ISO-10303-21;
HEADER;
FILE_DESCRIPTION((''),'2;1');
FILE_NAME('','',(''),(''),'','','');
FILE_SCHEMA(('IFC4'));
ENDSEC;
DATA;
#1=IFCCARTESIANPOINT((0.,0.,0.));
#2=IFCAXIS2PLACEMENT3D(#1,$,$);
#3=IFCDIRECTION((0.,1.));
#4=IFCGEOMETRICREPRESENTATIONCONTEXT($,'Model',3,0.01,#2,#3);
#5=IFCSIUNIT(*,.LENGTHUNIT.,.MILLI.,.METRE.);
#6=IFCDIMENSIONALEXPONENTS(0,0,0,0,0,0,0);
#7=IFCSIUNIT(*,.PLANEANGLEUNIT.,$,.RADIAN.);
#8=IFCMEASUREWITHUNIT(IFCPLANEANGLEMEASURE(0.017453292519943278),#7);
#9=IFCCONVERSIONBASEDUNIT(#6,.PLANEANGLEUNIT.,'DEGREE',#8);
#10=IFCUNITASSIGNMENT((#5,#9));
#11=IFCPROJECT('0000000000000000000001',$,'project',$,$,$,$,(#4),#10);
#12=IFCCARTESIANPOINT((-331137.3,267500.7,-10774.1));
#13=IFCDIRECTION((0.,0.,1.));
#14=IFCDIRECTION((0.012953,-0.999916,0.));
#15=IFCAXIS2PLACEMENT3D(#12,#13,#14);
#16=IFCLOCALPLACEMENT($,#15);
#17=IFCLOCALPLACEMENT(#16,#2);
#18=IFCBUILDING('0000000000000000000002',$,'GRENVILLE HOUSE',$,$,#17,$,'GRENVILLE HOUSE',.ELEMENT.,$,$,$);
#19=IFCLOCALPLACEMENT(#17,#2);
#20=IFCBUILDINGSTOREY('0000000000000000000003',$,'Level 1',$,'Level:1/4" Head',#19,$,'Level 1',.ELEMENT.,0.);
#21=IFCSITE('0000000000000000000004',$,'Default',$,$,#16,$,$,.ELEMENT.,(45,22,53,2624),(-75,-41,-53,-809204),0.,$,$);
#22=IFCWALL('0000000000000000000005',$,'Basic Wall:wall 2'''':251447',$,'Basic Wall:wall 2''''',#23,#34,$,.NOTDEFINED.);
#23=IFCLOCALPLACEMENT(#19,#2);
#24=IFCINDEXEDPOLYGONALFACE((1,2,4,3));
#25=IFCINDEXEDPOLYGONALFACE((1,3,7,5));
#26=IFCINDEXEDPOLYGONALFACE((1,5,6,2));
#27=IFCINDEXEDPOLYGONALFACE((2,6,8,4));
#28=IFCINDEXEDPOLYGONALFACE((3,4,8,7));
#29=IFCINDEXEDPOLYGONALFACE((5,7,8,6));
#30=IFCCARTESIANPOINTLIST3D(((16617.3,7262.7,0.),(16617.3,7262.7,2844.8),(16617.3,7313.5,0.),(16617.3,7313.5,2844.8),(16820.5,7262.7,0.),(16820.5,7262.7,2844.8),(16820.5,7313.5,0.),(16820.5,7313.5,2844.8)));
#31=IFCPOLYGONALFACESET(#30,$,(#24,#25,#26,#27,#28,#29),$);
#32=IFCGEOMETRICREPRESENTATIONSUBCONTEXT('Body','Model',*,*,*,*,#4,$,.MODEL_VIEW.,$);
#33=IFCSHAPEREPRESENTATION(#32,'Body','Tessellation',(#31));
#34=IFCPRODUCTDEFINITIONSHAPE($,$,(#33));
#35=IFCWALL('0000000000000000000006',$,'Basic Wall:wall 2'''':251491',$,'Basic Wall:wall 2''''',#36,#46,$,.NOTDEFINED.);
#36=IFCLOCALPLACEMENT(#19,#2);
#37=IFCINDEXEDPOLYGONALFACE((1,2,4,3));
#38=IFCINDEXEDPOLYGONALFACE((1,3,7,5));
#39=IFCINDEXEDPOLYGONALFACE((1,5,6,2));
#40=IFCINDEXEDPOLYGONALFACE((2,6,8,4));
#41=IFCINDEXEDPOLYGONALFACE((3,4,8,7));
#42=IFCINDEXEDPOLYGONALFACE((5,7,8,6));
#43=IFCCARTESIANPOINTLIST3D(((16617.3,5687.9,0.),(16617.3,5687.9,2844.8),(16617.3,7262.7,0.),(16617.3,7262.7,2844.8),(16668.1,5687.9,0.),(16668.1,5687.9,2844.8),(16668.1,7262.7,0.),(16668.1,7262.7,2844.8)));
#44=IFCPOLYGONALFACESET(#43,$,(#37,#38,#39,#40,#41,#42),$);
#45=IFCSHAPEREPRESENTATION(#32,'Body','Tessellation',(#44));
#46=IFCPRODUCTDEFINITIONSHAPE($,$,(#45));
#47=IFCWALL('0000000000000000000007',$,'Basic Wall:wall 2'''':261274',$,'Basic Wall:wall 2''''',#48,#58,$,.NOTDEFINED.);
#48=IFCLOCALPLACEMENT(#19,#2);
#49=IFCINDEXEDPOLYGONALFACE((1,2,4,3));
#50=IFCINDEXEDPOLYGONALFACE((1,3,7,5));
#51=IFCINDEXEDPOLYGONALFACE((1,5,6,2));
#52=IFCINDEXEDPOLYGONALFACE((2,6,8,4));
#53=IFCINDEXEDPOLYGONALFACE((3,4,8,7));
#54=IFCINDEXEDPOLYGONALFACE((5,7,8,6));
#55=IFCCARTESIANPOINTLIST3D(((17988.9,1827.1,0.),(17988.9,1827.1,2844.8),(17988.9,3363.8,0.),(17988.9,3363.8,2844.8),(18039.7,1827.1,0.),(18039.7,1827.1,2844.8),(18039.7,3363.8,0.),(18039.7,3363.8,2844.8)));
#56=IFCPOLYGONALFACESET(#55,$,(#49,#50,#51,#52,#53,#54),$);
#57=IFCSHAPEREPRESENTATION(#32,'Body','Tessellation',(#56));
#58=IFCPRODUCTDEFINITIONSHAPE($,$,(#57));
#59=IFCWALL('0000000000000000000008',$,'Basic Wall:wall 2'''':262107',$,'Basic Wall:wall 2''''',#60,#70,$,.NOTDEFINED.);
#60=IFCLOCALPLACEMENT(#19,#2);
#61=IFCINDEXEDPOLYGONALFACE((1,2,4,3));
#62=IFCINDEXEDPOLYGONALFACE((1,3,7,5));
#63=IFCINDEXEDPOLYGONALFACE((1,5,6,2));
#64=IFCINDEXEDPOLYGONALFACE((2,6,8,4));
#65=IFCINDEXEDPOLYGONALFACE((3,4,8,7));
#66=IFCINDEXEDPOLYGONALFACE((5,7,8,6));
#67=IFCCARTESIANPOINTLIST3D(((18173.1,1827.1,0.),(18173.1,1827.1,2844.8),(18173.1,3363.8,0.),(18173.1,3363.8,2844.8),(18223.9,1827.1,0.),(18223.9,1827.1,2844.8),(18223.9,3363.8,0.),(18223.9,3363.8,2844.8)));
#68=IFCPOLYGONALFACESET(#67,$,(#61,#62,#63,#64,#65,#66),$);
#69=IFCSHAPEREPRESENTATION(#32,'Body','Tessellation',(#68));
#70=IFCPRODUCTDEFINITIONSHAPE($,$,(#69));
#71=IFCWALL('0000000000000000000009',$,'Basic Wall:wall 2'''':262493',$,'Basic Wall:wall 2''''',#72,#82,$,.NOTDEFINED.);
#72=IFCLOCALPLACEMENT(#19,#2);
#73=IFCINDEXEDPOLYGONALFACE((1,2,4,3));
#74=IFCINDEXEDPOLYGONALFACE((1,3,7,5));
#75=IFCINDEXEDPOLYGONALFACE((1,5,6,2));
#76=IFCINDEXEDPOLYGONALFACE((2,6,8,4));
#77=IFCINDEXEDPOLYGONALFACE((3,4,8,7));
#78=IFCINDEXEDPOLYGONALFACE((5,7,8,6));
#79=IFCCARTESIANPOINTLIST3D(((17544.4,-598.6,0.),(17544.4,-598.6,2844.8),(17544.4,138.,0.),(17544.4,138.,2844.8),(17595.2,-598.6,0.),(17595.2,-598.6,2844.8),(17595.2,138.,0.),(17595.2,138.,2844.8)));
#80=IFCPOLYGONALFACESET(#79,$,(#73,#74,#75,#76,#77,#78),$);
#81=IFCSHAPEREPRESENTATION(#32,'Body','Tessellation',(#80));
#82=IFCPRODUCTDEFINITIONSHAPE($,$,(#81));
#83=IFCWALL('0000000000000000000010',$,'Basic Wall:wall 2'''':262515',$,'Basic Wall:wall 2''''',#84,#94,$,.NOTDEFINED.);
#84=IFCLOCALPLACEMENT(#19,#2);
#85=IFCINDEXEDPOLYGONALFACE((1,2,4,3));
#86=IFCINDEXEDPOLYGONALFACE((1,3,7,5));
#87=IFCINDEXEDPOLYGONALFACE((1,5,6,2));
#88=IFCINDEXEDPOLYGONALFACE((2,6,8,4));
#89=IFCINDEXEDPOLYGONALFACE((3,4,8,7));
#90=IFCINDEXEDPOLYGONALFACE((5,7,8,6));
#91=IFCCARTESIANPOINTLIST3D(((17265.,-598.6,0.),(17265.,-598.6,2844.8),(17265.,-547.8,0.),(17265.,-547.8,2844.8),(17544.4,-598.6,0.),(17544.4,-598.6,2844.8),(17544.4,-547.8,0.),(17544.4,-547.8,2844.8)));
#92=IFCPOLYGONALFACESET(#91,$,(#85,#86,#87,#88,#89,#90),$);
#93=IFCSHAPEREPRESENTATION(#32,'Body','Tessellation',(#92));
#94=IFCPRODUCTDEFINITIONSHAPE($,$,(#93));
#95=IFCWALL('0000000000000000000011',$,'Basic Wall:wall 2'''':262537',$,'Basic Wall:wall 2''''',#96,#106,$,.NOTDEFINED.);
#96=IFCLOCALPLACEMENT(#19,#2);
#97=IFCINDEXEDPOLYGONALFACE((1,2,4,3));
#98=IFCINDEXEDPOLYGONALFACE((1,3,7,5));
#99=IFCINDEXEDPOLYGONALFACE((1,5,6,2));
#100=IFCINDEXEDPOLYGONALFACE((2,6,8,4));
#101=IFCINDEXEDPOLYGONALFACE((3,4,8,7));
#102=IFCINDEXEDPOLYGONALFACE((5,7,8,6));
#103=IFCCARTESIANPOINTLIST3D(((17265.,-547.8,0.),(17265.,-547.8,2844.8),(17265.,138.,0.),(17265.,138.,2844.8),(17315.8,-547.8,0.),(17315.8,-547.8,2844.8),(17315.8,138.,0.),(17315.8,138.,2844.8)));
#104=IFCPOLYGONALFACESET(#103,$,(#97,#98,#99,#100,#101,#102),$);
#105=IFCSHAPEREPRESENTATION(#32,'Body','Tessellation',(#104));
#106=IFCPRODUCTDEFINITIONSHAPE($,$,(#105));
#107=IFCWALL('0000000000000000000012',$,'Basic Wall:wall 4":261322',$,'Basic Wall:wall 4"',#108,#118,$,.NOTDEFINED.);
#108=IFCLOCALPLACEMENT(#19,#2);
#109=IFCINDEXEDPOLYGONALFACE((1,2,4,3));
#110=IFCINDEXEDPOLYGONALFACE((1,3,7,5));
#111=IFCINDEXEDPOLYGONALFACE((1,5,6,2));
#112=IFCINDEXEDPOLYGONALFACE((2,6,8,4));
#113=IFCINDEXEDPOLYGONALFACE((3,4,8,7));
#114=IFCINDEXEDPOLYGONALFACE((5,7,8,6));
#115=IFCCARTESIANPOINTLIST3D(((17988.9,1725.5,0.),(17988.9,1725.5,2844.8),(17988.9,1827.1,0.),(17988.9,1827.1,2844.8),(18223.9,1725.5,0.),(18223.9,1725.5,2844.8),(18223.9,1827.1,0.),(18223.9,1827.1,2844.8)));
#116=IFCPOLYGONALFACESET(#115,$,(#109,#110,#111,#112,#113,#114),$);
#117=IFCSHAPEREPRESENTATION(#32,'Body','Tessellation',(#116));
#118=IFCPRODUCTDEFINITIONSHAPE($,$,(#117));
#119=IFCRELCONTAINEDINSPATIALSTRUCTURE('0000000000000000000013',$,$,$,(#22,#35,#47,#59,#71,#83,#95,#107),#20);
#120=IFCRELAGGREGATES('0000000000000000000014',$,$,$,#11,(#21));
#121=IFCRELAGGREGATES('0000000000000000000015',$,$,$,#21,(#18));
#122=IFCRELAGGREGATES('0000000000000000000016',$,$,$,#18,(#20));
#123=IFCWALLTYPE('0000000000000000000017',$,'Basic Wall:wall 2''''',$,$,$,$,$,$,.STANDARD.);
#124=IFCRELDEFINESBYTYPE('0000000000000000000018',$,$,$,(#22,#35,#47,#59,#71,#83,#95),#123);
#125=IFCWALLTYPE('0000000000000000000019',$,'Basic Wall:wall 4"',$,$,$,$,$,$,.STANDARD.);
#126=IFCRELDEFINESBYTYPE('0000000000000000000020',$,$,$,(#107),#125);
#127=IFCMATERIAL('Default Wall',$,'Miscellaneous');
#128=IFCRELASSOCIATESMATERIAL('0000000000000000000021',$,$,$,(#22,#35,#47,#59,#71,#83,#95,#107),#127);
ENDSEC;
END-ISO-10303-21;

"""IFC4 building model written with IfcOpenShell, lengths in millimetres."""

from ifc_helpers import new_model, entity, si_unit, converted_unit, direction, frame, origin, place, context, subcontext, project, spatial, indexed_curve, outline, extrude, material, type_object, element, save


model = new_model("IFC4")

# Units and contexts
model_context = context("Model", 3, precision=0.01, world=origin(), true_north=direction((0.0, 1.0)))
body_context = subcontext(model_context, "Body", "Model", "MODEL_VIEW")
ifc_project = project(units=[si_unit("LENGTHUNIT", "METRE", prefix="MILLI"), converted_unit("PLANEANGLEUNIT", "DEGREE", entity("IfcPlaneAngleMeasure", 0.017453292519943278), si_unit("PLANEANGLEUNIT", "RADIAN"), dimensions=[0, 0, 0, 0, 0, 0, 0])], contexts=[model_context])

# Site, building, storey
site_placement = place(None, frame((-331137.3, 267500.7, -10774.1), z_axis=(0.0, 0.0, 1.0), x_axis=(0.012953, -0.999916, 0.0)))
site = spatial("IfcSite", under=ifc_project, at=site_placement, Name="Default", CompositionType="ELEMENT", RefLatitude=(45, 22, 53, 2624), RefLongitude=(-75, -41, -53, -809204), RefElevation=0.0)
building_placement = place(site_placement, origin())
building = spatial("IfcBuilding", under=site, at=building_placement, Name="GRENVILLE HOUSE", LongName="GRENVILLE HOUSE", CompositionType="ELEMENT")
storey_placement = place(building_placement, origin())
storey = spatial("IfcBuildingStorey", under=building, at=storey_placement, Name="Level 1", ObjectType="Level:1/4\" Head", LongName="Level 1", CompositionType="ELEMENT", Elevation=0.0)

# Walls
ifc_material_1 = material(Name="Default Wall", Category="Miscellaneous")
wall_type_1 = type_object("IfcWallType", Name="Basic Wall:wall 2''", PredefinedType="STANDARD")
wall_1_placement = place(storey_placement, frame((16820.5, 7288.1, 0.0), z_axis=(0.0, 0.0, 1.0), x_axis=(-1.0, 0.0, 0.0)))
element("IfcWall", 1, at=wall_1_placement, inside=storey, type_object=wall_type_1, material=ifc_material_1, Name="Basic Wall:wall 2'':251447", ObjectType="Basic Wall:wall 2''", PredefinedType="NOTDEFINED", context=body_context, shape_type="SweptSolid", body=[
    extrude(outline(indexed_curve([(203.2, 25.4), (0.0, 25.4), (0.0, -25.4), (203.2, -25.4), (203.2, 25.4)], self_intersect=False)), origin(), (0.0, 0.0, 1.0), 2844.8),
])
wall_2_placement = place(storey_placement, frame((16642.7, 7262.7, 0.0), z_axis=(0.0, 0.0, 1.0), x_axis=(0.0, -1.0, 0.0)))
element("IfcWall", 2, at=wall_2_placement, inside=storey, type_object=wall_type_1, material=ifc_material_1, Name="Basic Wall:wall 2'':251491", ObjectType="Basic Wall:wall 2''", PredefinedType="NOTDEFINED", context=body_context, shape_type="SweptSolid", body=[
    extrude(outline(indexed_curve([(1574.8, 25.4), (0.0, 25.4), (0.0, -25.4), (1574.8, -25.4), (1574.8, 25.4)], self_intersect=False)), origin(), (0.0, 0.0, 1.0), 2844.8),
])
wall_3_placement = place(storey_placement, frame((18014.3, 3363.8, 0.0), z_axis=(0.0, 0.0, 1.0), x_axis=(0.0, -1.0, 0.0)))
element("IfcWall", 3, at=wall_3_placement, inside=storey, type_object=wall_type_1, material=ifc_material_1, Name="Basic Wall:wall 2'':261274", ObjectType="Basic Wall:wall 2''", PredefinedType="NOTDEFINED", context=body_context, shape_type="SweptSolid", body=[
    extrude(outline(indexed_curve([(1536.7, 25.4), (0.0, 25.4), (0.0, -25.4), (1536.7, -25.4), (1536.7, 25.4)], self_intersect=False)), origin(), (0.0, 0.0, 1.0), 2844.8),
])
wall_4_placement = place(storey_placement, frame((18198.5, 3363.8, 0.0), z_axis=(0.0, 0.0, 1.0), x_axis=(0.0, -1.0, 0.0)))
element("IfcWall", 4, at=wall_4_placement, inside=storey, type_object=wall_type_1, material=ifc_material_1, Name="Basic Wall:wall 2'':262107", ObjectType="Basic Wall:wall 2''", PredefinedType="NOTDEFINED", context=body_context, shape_type="SweptSolid", body=[
    extrude(outline(indexed_curve([(1536.7, 25.4), (0.0, 25.4), (0.0, -25.4), (1536.7, -25.4), (1536.7, 25.4)], self_intersect=False)), origin(), (0.0, 0.0, 1.0), 2844.8),
])
wall_5_placement = place(storey_placement, frame((17569.8, 138.0, 0.0), z_axis=(0.0, 0.0, 1.0), x_axis=(0.0, -1.0, 0.0)))
element("IfcWall", 5, at=wall_5_placement, inside=storey, type_object=wall_type_1, material=ifc_material_1, Name="Basic Wall:wall 2'':262493", ObjectType="Basic Wall:wall 2''", PredefinedType="NOTDEFINED", context=body_context, shape_type="SweptSolid", body=[
    extrude(outline(indexed_curve([(736.6, 25.4), (0.0, 25.4), (0.0, -25.4), (736.6, -25.4), (736.6, 25.4)], self_intersect=False)), origin(), (0.0, 0.0, 1.0), 2844.8),
])
wall_6_placement = place(storey_placement, frame((17544.4, -573.2, 0.0), z_axis=(0.0, 0.0, 1.0), x_axis=(-1.0, 0.0, 0.0)))
element("IfcWall", 6, at=wall_6_placement, inside=storey, type_object=wall_type_1, material=ifc_material_1, Name="Basic Wall:wall 2'':262515", ObjectType="Basic Wall:wall 2''", PredefinedType="NOTDEFINED", context=body_context, shape_type="SweptSolid", body=[
    extrude(outline(indexed_curve([(279.4, 25.4), (0.0, 25.4), (0.0, -25.4), (279.4, -25.4), (279.4, 25.4)], self_intersect=False)), origin(), (0.0, 0.0, 1.0), 2844.8),
])
wall_7_placement = place(storey_placement, frame((17290.4, -547.8, 0.0), z_axis=(0.0, 0.0, 1.0), x_axis=(0.0, 1.0, 0.0)))
element("IfcWall", 7, at=wall_7_placement, inside=storey, type_object=wall_type_1, material=ifc_material_1, Name="Basic Wall:wall 2'':262537", ObjectType="Basic Wall:wall 2''", PredefinedType="NOTDEFINED", context=body_context, shape_type="SweptSolid", body=[
    extrude(outline(indexed_curve([(685.8, 25.4), (0.0, 25.4), (0.0, -25.4), (685.8, -25.4), (685.8, 25.4)], self_intersect=False)), origin(), (0.0, 0.0, 1.0), 2844.8),
])
wall_type_2 = type_object("IfcWallType", Name="Basic Wall:wall 4\"", PredefinedType="STANDARD")
wall_8_placement = place(storey_placement, frame((17988.9, 1776.3, 0.0)))
element("IfcWall", 8, at=wall_8_placement, inside=storey, type_object=wall_type_2, material=ifc_material_1, Name="Basic Wall:wall 4\":261322", ObjectType="Basic Wall:wall 4\"", PredefinedType="NOTDEFINED", context=body_context, shape_type="SweptSolid", body=[
    extrude(outline(indexed_curve([(234.9, 50.8), (0.0, 50.8), (0.0, -50.8), (234.9, -50.8), (234.9, 50.8)], self_intersect=False)), origin(), (0.0, 0.0, 1.0), 2844.8),
])

save(model, "model.ifc")
